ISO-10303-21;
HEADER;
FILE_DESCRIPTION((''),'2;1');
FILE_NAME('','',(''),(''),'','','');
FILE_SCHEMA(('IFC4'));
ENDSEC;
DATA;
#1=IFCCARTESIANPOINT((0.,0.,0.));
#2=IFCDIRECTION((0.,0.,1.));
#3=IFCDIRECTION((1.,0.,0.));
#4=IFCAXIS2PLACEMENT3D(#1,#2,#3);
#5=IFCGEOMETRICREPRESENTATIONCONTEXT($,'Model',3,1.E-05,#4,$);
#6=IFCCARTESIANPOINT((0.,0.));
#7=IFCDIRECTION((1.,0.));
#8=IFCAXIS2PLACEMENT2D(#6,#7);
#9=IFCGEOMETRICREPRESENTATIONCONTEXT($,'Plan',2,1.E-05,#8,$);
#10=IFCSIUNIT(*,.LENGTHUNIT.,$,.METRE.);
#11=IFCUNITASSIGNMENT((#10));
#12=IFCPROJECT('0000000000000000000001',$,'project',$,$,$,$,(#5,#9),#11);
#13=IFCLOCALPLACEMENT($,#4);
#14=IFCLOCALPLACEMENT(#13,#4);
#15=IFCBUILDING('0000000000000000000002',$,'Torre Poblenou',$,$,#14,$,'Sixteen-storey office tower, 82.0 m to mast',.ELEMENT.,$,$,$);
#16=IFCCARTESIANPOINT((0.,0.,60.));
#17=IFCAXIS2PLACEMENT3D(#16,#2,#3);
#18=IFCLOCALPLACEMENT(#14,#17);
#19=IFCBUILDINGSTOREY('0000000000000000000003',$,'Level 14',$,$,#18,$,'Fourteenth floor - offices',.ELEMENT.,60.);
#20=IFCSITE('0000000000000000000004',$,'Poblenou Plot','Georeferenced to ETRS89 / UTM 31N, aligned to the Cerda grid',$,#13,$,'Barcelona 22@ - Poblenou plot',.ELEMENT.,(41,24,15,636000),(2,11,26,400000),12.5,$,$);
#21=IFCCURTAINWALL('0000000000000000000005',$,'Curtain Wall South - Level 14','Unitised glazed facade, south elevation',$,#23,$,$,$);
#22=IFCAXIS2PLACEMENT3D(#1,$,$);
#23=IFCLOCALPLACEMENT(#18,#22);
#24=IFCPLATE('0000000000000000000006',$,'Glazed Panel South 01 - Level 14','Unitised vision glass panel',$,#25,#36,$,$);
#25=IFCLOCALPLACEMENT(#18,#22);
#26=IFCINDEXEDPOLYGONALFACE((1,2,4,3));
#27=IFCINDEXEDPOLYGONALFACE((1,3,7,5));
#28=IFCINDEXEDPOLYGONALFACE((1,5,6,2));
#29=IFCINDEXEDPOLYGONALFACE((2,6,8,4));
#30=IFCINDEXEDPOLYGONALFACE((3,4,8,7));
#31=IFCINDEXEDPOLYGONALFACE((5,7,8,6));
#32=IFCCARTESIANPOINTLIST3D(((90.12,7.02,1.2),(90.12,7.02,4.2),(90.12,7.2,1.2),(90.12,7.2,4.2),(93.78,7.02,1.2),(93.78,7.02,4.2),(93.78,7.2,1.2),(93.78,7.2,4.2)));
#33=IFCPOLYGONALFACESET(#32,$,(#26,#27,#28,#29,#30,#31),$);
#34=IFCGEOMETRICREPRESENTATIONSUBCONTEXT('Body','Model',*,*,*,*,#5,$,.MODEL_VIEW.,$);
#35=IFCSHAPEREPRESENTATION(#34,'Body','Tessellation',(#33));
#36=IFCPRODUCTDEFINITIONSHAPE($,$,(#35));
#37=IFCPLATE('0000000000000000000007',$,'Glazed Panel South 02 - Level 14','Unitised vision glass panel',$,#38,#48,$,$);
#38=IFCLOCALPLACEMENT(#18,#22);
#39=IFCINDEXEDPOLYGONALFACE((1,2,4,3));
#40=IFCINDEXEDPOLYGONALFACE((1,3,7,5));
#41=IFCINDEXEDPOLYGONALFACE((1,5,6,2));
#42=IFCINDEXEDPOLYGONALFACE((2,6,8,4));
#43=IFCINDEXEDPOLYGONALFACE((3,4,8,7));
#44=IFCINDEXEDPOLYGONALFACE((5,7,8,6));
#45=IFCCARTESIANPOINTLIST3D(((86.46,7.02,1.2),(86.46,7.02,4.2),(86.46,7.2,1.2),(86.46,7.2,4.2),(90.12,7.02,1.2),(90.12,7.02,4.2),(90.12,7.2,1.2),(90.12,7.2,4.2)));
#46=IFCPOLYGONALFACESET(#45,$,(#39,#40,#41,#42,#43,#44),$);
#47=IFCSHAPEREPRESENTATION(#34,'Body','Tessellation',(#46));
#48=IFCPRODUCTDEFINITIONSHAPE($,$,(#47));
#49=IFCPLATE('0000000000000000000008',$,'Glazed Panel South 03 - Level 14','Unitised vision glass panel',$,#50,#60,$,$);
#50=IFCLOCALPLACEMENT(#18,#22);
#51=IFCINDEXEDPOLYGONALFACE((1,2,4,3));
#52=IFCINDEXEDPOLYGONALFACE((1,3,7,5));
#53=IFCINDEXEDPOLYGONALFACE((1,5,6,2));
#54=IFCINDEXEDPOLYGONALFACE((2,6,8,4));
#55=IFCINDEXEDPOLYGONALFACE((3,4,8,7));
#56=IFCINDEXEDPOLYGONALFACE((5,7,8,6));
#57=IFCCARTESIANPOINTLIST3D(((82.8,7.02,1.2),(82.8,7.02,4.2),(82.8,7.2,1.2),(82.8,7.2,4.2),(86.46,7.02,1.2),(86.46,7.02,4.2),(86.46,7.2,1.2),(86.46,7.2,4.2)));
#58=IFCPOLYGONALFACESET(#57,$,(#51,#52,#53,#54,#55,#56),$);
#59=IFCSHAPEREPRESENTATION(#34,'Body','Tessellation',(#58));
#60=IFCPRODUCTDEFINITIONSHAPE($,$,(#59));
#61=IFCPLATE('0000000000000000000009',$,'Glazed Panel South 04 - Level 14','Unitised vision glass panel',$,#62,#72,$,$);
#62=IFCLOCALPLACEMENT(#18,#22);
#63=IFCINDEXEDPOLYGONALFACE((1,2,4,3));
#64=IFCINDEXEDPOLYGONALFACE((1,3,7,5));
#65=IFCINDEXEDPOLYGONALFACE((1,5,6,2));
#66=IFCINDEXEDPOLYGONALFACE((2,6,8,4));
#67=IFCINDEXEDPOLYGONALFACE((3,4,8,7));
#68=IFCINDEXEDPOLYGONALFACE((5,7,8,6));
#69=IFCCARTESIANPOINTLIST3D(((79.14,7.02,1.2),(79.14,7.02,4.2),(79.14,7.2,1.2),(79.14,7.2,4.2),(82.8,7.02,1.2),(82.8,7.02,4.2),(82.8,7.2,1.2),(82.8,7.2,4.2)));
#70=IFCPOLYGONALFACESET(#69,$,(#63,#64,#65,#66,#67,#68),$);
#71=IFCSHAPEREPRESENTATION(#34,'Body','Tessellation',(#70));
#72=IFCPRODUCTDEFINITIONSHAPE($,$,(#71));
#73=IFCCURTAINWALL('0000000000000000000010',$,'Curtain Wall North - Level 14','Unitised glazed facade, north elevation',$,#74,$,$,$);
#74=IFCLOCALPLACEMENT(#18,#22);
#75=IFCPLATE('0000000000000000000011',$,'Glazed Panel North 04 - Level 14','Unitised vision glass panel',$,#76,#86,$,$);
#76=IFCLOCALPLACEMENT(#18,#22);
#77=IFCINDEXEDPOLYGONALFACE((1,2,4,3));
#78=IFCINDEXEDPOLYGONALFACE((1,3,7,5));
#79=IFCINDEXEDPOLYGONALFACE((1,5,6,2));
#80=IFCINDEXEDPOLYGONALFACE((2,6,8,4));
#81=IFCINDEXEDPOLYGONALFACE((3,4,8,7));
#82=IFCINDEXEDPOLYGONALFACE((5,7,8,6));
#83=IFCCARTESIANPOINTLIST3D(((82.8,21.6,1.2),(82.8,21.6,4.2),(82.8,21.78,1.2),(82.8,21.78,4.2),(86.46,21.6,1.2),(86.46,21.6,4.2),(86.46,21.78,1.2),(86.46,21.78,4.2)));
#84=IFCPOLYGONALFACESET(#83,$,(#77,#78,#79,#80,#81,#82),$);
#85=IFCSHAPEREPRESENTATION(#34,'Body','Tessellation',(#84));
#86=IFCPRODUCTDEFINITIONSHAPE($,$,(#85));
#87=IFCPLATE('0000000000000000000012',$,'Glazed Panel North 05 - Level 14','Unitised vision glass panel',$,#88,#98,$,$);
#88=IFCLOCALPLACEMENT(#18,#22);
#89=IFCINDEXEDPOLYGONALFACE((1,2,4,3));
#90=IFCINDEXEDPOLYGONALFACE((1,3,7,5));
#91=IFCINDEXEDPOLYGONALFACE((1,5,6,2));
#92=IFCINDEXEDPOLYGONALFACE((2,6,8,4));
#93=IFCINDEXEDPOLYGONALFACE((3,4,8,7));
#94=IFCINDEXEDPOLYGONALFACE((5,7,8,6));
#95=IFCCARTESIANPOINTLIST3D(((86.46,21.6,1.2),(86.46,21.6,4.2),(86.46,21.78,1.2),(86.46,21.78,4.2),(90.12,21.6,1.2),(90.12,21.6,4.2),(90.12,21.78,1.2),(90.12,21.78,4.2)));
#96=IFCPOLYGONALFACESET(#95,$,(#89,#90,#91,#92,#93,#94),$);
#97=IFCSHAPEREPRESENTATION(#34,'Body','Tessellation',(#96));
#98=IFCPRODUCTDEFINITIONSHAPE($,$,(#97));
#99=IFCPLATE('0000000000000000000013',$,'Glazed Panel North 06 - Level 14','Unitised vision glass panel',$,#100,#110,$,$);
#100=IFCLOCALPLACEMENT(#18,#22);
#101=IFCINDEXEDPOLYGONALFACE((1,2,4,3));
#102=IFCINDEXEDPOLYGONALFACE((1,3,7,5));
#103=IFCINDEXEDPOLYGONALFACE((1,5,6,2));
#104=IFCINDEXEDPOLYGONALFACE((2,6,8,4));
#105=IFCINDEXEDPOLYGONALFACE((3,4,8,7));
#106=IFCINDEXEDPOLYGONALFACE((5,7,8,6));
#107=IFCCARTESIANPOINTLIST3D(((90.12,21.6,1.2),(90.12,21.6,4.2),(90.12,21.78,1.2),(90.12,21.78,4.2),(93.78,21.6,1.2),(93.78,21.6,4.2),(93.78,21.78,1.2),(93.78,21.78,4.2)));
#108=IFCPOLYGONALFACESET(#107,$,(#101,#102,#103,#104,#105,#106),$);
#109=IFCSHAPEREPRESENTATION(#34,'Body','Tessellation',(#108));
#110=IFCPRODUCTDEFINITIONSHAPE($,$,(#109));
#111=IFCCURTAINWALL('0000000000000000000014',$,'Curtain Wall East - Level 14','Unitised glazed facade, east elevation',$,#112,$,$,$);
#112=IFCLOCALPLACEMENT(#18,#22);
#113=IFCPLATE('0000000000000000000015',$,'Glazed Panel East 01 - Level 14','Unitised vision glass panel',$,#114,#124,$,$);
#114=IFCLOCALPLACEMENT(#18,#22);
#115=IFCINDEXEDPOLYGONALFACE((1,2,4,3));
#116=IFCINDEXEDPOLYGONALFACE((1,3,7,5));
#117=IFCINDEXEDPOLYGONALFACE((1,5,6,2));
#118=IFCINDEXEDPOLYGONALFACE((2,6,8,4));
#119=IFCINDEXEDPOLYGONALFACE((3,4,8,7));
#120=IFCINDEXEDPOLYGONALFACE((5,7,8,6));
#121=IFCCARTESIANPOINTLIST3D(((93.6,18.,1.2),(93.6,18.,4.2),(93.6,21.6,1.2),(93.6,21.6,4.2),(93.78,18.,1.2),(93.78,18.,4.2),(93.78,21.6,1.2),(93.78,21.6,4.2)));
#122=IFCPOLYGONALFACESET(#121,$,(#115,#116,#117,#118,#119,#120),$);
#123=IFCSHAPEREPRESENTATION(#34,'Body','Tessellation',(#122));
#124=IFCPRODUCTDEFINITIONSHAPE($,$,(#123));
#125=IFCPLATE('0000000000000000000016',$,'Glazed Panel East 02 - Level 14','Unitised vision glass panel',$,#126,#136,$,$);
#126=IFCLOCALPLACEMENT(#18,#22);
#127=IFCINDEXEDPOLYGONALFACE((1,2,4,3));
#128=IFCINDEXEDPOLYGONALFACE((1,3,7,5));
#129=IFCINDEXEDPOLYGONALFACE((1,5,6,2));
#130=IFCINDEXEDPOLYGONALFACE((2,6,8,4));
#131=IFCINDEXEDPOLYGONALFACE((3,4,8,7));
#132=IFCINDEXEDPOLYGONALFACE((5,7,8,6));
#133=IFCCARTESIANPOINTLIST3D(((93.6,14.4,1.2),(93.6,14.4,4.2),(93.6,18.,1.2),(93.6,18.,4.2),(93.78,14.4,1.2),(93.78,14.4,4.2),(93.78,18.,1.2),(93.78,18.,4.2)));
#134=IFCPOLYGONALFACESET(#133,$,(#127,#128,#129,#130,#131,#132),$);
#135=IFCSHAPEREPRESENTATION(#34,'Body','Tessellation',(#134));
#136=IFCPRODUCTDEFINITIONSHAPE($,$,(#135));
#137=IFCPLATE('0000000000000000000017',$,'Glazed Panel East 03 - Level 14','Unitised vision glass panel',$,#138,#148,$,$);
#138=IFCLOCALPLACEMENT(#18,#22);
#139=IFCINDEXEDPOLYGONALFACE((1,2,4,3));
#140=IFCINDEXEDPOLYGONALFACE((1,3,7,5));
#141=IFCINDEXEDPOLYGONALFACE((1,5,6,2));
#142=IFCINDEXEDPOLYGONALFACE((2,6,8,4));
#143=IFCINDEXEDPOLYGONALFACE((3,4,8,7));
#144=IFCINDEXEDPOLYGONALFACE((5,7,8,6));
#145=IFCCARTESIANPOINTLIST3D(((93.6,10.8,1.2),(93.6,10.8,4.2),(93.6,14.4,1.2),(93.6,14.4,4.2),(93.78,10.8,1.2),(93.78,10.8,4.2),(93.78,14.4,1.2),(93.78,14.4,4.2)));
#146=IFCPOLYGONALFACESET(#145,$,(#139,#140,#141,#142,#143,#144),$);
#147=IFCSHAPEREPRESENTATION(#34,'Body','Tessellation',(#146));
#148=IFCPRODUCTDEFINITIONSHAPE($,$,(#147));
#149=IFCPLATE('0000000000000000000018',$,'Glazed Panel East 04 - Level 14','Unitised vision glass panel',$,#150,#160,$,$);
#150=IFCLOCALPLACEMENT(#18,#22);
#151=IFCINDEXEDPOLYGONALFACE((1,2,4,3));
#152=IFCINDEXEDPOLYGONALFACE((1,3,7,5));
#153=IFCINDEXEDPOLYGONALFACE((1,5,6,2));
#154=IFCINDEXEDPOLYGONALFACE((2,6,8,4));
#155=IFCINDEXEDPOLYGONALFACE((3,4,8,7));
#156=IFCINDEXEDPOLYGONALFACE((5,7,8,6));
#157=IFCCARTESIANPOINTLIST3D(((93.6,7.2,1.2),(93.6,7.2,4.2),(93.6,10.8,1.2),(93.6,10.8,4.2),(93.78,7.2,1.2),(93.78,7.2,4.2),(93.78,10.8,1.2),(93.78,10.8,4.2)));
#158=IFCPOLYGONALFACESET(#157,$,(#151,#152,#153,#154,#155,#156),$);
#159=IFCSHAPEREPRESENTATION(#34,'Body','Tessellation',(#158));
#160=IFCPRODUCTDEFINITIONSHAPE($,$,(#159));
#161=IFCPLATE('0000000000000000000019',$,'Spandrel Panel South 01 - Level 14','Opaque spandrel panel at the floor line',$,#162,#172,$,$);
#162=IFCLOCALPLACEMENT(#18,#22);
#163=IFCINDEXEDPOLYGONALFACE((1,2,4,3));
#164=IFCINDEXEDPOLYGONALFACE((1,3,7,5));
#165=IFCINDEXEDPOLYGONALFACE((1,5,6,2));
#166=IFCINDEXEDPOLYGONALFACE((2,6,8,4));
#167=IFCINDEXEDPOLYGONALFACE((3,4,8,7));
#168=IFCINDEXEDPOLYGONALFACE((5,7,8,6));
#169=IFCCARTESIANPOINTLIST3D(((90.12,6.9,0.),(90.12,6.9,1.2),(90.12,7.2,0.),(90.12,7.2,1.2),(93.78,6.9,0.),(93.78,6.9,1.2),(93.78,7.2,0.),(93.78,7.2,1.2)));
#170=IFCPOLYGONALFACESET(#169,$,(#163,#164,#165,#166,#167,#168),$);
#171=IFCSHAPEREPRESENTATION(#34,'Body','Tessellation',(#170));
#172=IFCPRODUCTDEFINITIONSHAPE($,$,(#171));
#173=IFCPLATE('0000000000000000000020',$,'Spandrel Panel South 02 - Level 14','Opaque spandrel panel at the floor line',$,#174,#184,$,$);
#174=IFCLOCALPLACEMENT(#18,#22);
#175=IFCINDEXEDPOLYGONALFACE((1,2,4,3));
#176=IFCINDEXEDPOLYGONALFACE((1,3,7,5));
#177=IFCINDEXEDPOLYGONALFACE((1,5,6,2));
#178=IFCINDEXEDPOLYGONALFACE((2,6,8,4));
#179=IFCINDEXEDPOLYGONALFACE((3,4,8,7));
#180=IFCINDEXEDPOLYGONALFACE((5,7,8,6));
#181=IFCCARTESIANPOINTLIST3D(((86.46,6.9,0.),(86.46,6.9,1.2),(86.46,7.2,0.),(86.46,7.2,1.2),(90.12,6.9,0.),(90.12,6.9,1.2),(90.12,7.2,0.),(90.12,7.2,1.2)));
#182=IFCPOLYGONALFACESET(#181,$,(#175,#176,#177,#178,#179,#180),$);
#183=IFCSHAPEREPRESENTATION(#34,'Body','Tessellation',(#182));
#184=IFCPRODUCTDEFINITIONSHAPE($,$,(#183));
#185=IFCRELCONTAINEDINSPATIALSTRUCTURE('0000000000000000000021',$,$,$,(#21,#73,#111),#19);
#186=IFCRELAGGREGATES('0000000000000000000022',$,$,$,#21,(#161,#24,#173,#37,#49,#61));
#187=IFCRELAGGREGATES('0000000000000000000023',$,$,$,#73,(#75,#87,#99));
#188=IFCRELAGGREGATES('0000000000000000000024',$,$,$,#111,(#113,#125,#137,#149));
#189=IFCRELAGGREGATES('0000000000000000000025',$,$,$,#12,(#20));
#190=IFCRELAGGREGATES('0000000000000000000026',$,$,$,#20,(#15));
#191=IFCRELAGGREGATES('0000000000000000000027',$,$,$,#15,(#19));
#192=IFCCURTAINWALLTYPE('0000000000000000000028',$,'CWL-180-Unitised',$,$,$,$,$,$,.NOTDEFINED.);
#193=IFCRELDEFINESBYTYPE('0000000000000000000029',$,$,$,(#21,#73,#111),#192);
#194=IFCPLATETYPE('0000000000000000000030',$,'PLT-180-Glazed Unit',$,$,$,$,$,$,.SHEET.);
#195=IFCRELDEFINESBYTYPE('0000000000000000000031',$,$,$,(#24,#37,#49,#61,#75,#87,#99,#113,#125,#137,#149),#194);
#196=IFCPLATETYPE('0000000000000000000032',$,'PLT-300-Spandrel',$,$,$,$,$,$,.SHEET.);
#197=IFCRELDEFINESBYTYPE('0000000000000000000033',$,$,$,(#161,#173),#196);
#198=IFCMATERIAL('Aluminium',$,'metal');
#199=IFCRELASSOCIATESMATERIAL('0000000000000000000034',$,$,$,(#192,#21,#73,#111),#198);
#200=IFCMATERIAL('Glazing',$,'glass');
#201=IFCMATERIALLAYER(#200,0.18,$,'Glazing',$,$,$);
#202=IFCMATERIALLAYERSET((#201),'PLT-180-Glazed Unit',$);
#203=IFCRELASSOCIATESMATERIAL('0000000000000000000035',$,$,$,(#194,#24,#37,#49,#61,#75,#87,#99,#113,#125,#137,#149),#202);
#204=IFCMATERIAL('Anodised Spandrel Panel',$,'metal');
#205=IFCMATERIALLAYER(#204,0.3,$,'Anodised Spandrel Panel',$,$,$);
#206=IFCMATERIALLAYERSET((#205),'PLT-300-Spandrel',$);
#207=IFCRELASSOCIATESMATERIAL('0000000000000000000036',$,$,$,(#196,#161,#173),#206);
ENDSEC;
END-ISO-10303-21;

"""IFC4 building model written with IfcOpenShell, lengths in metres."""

from ifc_helpers import new_model, si_unit, frame, origin_with_axes, origin_2d_with_axis, place, context, subcontext, project, spatial, line, indexed_curve, outline, extrude, material, layer, layer_set, layer_usage, type_object, element, aggregate, save


model = new_model("IFC4")

# Units and contexts
model_context = context("Model", 3, precision=1e-05, world=origin_with_axes())
plan_context = context("Plan", 2, precision=1e-05, world=origin_2d_with_axis())
body_context = subcontext(model_context, "Body", "Model", "MODEL_VIEW")
ifc_project = project(units=[si_unit("LENGTHUNIT", "METRE")], contexts=[model_context, plan_context])

# Site, building, storey
site_placement = place(None, origin_with_axes())
site = spatial("IfcSite", under=ifc_project, at=site_placement, Name="Poblenou Plot", Description="Georeferenced to ETRS89 / UTM 31N, aligned to the Cerda grid", LongName="Barcelona 22@ - Poblenou plot", CompositionType="ELEMENT", RefLatitude=(41, 24, 15, 636000), RefLongitude=(2, 11, 26, 400000), RefElevation=12.5)
building_placement = place(site_placement, origin_with_axes())
building = spatial("IfcBuilding", under=site, at=building_placement, Name="Torre Poblenou", LongName="Sixteen-storey office tower, 82.0 m to mast", CompositionType="ELEMENT")
storey_placement = place(building_placement, frame((0.0, 0.0, 60.0), z_axis=(0.0, 0.0, 1.0), x_axis=(1.0, 0.0, 0.0)))
storey = spatial("IfcBuildingStorey", under=building, at=storey_placement, Name="Level 14", LongName="Fourteenth floor - offices", CompositionType="ELEMENT", Elevation=60.0)

# Curtain walls, plates
ifc_material_1 = material(Name="Aluminium", Category="metal")
curtain_wall_type = type_object("IfcCurtainWallType", Name="CWL-180-Unitised", PredefinedType="NOTDEFINED", material=ifc_material_1)
curtain_wall_1_placement = place(storey_placement, frame((93.78, 7.2, 0.0), z_axis=(0.0, 0.0, 1.0), x_axis=(-1.0, 0.0, 0.0)))
curtain_wall_1 = element("IfcCurtainWall", 1, at=curtain_wall_1_placement, inside=storey, type_object=curtain_wall_type, material=ifc_material_1, Name="Curtain Wall South - Level 14", Description="Unitised glazed facade, south elevation")
ifc_material_2 = material(Name="Glazing", Category="glass")
ifc_layer_1 = layer(ifc_material_2, 0.18, Name="Glazing")
ifc_layer_set_1 = layer_set([ifc_layer_1], Name="PLT-180-Glazed Unit")
ifc_layer_usage_1 = layer_usage(ifc_layer_set_1, "AXIS2", "POSITIVE", 0.0)
plate_type_1 = type_object("IfcPlateType", Name="PLT-180-Glazed Unit", PredefinedType="SHEET", material=ifc_layer_set_1)
plate_1_placement = place(curtain_wall_1_placement, frame((0.0, 0.0, 1.2), z_axis=(0.0, 0.0, 1.0), x_axis=(1.0, 0.0, 0.0)))
plate_1 = element("IfcPlate", 2, at=plate_1_placement, type_object=plate_type_1, material=ifc_layer_usage_1, Name="Glazed Panel South 01 - Level 14", Description="Unitised vision glass panel", context=body_context, shape_type="SweptSolid", body=[
    extrude(outline(indexed_curve([(0.0, 0.0), (3.66, 0.0), (3.66, 0.18), (0.0, 0.18)], segments=[line(1, 2, 3, 4, 1)])), origin_with_axes(), (0.0, 0.0, 1.0), 3.0),
])
ifc_layer_usage_2 = layer_usage(ifc_layer_set_1, "AXIS2", "POSITIVE", 0.0)
plate_2_placement = place(curtain_wall_1_placement, frame((3.66, 0.0, 1.2), z_axis=(0.0, 0.0, 1.0), x_axis=(1.0, 0.0, 0.0)))
plate_2 = element("IfcPlate", 3, at=plate_2_placement, type_object=plate_type_1, material=ifc_layer_usage_2, Name="Glazed Panel South 02 - Level 14", Description="Unitised vision glass panel", context=body_context, shape_type="SweptSolid", body=[
    extrude(outline(indexed_curve([(0.0, 0.0), (3.66, 0.0), (3.66, 0.18), (0.0, 0.18)], segments=[line(1, 2, 3, 4, 1)])), origin_with_axes(), (0.0, 0.0, 1.0), 3.0),
])
ifc_layer_usage_3 = layer_usage(ifc_layer_set_1, "AXIS2", "POSITIVE", 0.0)
plate_3_placement = place(curtain_wall_1_placement, frame((7.32, 0.0, 1.2), z_axis=(0.0, 0.0, 1.0), x_axis=(1.0, 0.0, 0.0)))
plate_3 = element("IfcPlate", 4, at=plate_3_placement, type_object=plate_type_1, material=ifc_layer_usage_3, Name="Glazed Panel South 03 - Level 14", Description="Unitised vision glass panel", context=body_context, shape_type="SweptSolid", body=[
    extrude(outline(indexed_curve([(0.0, 0.0), (3.66, 0.0), (3.66, 0.18), (0.0, 0.18)], segments=[line(1, 2, 3, 4, 1)])), origin_with_axes(), (0.0, 0.0, 1.0), 3.0),
])
ifc_layer_usage_4 = layer_usage(ifc_layer_set_1, "AXIS2", "POSITIVE", 0.0)
plate_4_placement = place(curtain_wall_1_placement, frame((10.98, 0.0, 1.2), z_axis=(0.0, 0.0, 1.0), x_axis=(1.0, 0.0, 0.0)))
plate_4 = element("IfcPlate", 5, at=plate_4_placement, type_object=plate_type_1, material=ifc_layer_usage_4, Name="Glazed Panel South 04 - Level 14", Description="Unitised vision glass panel", context=body_context, shape_type="SweptSolid", body=[
    extrude(outline(indexed_curve([(0.0, 0.0), (3.66, 0.0), (3.66, 0.18), (0.0, 0.18)], segments=[line(1, 2, 3, 4, 1)])), origin_with_axes(), (0.0, 0.0, 1.0), 3.0),
])
curtain_wall_2_placement = place(storey_placement, frame((71.82, 21.6, 0.0), z_axis=(0.0, 0.0, 1.0), x_axis=(1.0, 0.0, 0.0)))
curtain_wall_2 = element("IfcCurtainWall", 6, at=curtain_wall_2_placement, inside=storey, type_object=curtain_wall_type, material=ifc_material_1, Name="Curtain Wall North - Level 14", Description="Unitised glazed facade, north elevation")
ifc_layer_usage_5 = layer_usage(ifc_layer_set_1, "AXIS2", "POSITIVE", 0.0)
plate_5_placement = place(curtain_wall_2_placement, frame((10.98, 0.0, 1.2), z_axis=(0.0, 0.0, 1.0), x_axis=(1.0, 0.0, 0.0)))
plate_5 = element("IfcPlate", 7, at=plate_5_placement, type_object=plate_type_1, material=ifc_layer_usage_5, Name="Glazed Panel North 04 - Level 14", Description="Unitised vision glass panel", context=body_context, shape_type="SweptSolid", body=[
    extrude(outline(indexed_curve([(0.0, 0.0), (3.66, 0.0), (3.66, 0.18), (0.0, 0.18)], segments=[line(1, 2, 3, 4, 1)])), origin_with_axes(), (0.0, 0.0, 1.0), 3.0),
])
ifc_layer_usage_6 = layer_usage(ifc_layer_set_1, "AXIS2", "POSITIVE", 0.0)
plate_6_placement = place(curtain_wall_2_placement, frame((14.64, 0.0, 1.2), z_axis=(0.0, 0.0, 1.0), x_axis=(1.0, 0.0, 0.0)))
plate_6 = element("IfcPlate", 8, at=plate_6_placement, type_object=plate_type_1, material=ifc_layer_usage_6, Name="Glazed Panel North 05 - Level 14", Description="Unitised vision glass panel", context=body_context, shape_type="SweptSolid", body=[
    extrude(outline(indexed_curve([(0.0, 0.0), (3.66, 0.0), (3.66, 0.18), (0.0, 0.18)], segments=[line(1, 2, 3, 4, 1)])), origin_with_axes(), (0.0, 0.0, 1.0), 3.0),
])
ifc_layer_usage_7 = layer_usage(ifc_layer_set_1, "AXIS2", "POSITIVE", 0.0)
plate_7_placement = place(curtain_wall_2_placement, frame((18.3, 0.0, 1.2), z_axis=(0.0, 0.0, 1.0), x_axis=(1.0, 0.0, 0.0)))
plate_7 = element("IfcPlate", 9, at=plate_7_placement, type_object=plate_type_1, material=ifc_layer_usage_7, Name="Glazed Panel North 06 - Level 14", Description="Unitised vision glass panel", context=body_context, shape_type="SweptSolid", body=[
    extrude(outline(indexed_curve([(0.0, 0.0), (3.66, 0.0), (3.66, 0.18), (0.0, 0.18)], segments=[line(1, 2, 3, 4, 1)])), origin_with_axes(), (0.0, 0.0, 1.0), 3.0),
])
curtain_wall_3_placement = place(storey_placement, frame((93.6, 21.6, 0.0), z_axis=(0.0, 0.0, 1.0), x_axis=(0.0, -1.0, 0.0)))
curtain_wall_3 = element("IfcCurtainWall", 10, at=curtain_wall_3_placement, inside=storey, type_object=curtain_wall_type, material=ifc_material_1, Name="Curtain Wall East - Level 14", Description="Unitised glazed facade, east elevation")
ifc_layer_usage_8 = layer_usage(ifc_layer_set_1, "AXIS2", "POSITIVE", 0.0)
plate_8_placement = place(curtain_wall_3_placement, frame((0.0, 0.0, 1.2), z_axis=(0.0, 0.0, 1.0), x_axis=(1.0, 0.0, 0.0)))
plate_8 = element("IfcPlate", 11, at=plate_8_placement, type_object=plate_type_1, material=ifc_layer_usage_8, Name="Glazed Panel East 01 - Level 14", Description="Unitised vision glass panel", context=body_context, shape_type="SweptSolid", body=[
    extrude(outline(indexed_curve([(0.0, 0.0), (3.6, 0.0), (3.6, 0.18), (0.0, 0.18)], segments=[line(1, 2, 3, 4, 1)])), origin_with_axes(), (0.0, 0.0, 1.0), 3.0),
])
ifc_layer_usage_9 = layer_usage(ifc_layer_set_1, "AXIS2", "POSITIVE", 0.0)
plate_9_placement = place(curtain_wall_3_placement, frame((3.6, 0.0, 1.2), z_axis=(0.0, 0.0, 1.0), x_axis=(1.0, 0.0, 0.0)))
plate_9 = element("IfcPlate", 12, at=plate_9_placement, type_object=plate_type_1, material=ifc_layer_usage_9, Name="Glazed Panel East 02 - Level 14", Description="Unitised vision glass panel", context=body_context, shape_type="SweptSolid", body=[
    extrude(outline(indexed_curve([(0.0, 0.0), (3.6, 0.0), (3.6, 0.18), (0.0, 0.18)], segments=[line(1, 2, 3, 4, 1)])), origin_with_axes(), (0.0, 0.0, 1.0), 3.0),
])
ifc_layer_usage_10 = layer_usage(ifc_layer_set_1, "AXIS2", "POSITIVE", 0.0)
plate_10_placement = place(curtain_wall_3_placement, frame((7.2, 0.0, 1.2), z_axis=(0.0, 0.0, 1.0), x_axis=(1.0, 0.0, 0.0)))
plate_10 = element("IfcPlate", 13, at=plate_10_placement, type_object=plate_type_1, material=ifc_layer_usage_10, Name="Glazed Panel East 03 - Level 14", Description="Unitised vision glass panel", context=body_context, shape_type="SweptSolid", body=[
    extrude(outline(indexed_curve([(0.0, 0.0), (3.6, 0.0), (3.6, 0.18), (0.0, 0.18)], segments=[line(1, 2, 3, 4, 1)])), origin_with_axes(), (0.0, 0.0, 1.0), 3.0),
])
ifc_layer_usage_11 = layer_usage(ifc_layer_set_1, "AXIS2", "POSITIVE", 0.0)
plate_11_placement = place(curtain_wall_3_placement, frame((10.8, 0.0, 1.2), z_axis=(0.0, 0.0, 1.0), x_axis=(1.0, 0.0, 0.0)))
plate_11 = element("IfcPlate", 14, at=plate_11_placement, type_object=plate_type_1, material=ifc_layer_usage_11, Name="Glazed Panel East 04 - Level 14", Description="Unitised vision glass panel", context=body_context, shape_type="SweptSolid", body=[
    extrude(outline(indexed_curve([(0.0, 0.0), (3.6, 0.0), (3.6, 0.18), (0.0, 0.18)], segments=[line(1, 2, 3, 4, 1)])), origin_with_axes(), (0.0, 0.0, 1.0), 3.0),
])

# Plates
ifc_material_3 = material(Name="Anodised Spandrel Panel", Category="metal")
ifc_layer_2 = layer(ifc_material_3, 0.3, Name="Anodised Spandrel Panel")
ifc_layer_set_2 = layer_set([ifc_layer_2], Name="PLT-300-Spandrel")
ifc_layer_usage_12 = layer_usage(ifc_layer_set_2, "AXIS2", "POSITIVE", 0.0)
plate_type_2 = type_object("IfcPlateType", Name="PLT-300-Spandrel", PredefinedType="SHEET", material=ifc_layer_set_2)
plate_12_placement = place(curtain_wall_1_placement, origin_with_axes())
plate_12 = element("IfcPlate", 15, at=plate_12_placement, type_object=plate_type_2, material=ifc_layer_usage_12, Name="Spandrel Panel South 01 - Level 14", Description="Opaque spandrel panel at the floor line", context=body_context, shape_type="SweptSolid", body=[
    extrude(outline(indexed_curve([(0.0, 0.0), (3.66, 0.0), (3.66, 0.3), (0.0, 0.3)], segments=[line(1, 2, 3, 4, 1)])), origin_with_axes(), (0.0, 0.0, 1.0), 1.2),
])
ifc_layer_usage_13 = layer_usage(ifc_layer_set_2, "AXIS2", "POSITIVE", 0.0)
plate_13_placement = place(curtain_wall_1_placement, frame((3.66, 0.0, 0.0), z_axis=(0.0, 0.0, 1.0), x_axis=(1.0, 0.0, 0.0)))
plate_13 = element("IfcPlate", 16, at=plate_13_placement, type_object=plate_type_2, material=ifc_layer_usage_13, Name="Spandrel Panel South 02 - Level 14", Description="Opaque spandrel panel at the floor line", context=body_context, shape_type="SweptSolid", body=[
    extrude(outline(indexed_curve([(0.0, 0.0), (3.66, 0.0), (3.66, 0.3), (0.0, 0.3)], segments=[line(1, 2, 3, 4, 1)])), origin_with_axes(), (0.0, 0.0, 1.0), 1.2),
])
aggregate(curtain_wall_1, [plate_12, plate_1, plate_13, plate_2, plate_3, plate_4])
aggregate(curtain_wall_2, [plate_5, plate_6, plate_7])
aggregate(curtain_wall_3, [plate_8, plate_9, plate_10, plate_11])

save(model, "model.ifc")
